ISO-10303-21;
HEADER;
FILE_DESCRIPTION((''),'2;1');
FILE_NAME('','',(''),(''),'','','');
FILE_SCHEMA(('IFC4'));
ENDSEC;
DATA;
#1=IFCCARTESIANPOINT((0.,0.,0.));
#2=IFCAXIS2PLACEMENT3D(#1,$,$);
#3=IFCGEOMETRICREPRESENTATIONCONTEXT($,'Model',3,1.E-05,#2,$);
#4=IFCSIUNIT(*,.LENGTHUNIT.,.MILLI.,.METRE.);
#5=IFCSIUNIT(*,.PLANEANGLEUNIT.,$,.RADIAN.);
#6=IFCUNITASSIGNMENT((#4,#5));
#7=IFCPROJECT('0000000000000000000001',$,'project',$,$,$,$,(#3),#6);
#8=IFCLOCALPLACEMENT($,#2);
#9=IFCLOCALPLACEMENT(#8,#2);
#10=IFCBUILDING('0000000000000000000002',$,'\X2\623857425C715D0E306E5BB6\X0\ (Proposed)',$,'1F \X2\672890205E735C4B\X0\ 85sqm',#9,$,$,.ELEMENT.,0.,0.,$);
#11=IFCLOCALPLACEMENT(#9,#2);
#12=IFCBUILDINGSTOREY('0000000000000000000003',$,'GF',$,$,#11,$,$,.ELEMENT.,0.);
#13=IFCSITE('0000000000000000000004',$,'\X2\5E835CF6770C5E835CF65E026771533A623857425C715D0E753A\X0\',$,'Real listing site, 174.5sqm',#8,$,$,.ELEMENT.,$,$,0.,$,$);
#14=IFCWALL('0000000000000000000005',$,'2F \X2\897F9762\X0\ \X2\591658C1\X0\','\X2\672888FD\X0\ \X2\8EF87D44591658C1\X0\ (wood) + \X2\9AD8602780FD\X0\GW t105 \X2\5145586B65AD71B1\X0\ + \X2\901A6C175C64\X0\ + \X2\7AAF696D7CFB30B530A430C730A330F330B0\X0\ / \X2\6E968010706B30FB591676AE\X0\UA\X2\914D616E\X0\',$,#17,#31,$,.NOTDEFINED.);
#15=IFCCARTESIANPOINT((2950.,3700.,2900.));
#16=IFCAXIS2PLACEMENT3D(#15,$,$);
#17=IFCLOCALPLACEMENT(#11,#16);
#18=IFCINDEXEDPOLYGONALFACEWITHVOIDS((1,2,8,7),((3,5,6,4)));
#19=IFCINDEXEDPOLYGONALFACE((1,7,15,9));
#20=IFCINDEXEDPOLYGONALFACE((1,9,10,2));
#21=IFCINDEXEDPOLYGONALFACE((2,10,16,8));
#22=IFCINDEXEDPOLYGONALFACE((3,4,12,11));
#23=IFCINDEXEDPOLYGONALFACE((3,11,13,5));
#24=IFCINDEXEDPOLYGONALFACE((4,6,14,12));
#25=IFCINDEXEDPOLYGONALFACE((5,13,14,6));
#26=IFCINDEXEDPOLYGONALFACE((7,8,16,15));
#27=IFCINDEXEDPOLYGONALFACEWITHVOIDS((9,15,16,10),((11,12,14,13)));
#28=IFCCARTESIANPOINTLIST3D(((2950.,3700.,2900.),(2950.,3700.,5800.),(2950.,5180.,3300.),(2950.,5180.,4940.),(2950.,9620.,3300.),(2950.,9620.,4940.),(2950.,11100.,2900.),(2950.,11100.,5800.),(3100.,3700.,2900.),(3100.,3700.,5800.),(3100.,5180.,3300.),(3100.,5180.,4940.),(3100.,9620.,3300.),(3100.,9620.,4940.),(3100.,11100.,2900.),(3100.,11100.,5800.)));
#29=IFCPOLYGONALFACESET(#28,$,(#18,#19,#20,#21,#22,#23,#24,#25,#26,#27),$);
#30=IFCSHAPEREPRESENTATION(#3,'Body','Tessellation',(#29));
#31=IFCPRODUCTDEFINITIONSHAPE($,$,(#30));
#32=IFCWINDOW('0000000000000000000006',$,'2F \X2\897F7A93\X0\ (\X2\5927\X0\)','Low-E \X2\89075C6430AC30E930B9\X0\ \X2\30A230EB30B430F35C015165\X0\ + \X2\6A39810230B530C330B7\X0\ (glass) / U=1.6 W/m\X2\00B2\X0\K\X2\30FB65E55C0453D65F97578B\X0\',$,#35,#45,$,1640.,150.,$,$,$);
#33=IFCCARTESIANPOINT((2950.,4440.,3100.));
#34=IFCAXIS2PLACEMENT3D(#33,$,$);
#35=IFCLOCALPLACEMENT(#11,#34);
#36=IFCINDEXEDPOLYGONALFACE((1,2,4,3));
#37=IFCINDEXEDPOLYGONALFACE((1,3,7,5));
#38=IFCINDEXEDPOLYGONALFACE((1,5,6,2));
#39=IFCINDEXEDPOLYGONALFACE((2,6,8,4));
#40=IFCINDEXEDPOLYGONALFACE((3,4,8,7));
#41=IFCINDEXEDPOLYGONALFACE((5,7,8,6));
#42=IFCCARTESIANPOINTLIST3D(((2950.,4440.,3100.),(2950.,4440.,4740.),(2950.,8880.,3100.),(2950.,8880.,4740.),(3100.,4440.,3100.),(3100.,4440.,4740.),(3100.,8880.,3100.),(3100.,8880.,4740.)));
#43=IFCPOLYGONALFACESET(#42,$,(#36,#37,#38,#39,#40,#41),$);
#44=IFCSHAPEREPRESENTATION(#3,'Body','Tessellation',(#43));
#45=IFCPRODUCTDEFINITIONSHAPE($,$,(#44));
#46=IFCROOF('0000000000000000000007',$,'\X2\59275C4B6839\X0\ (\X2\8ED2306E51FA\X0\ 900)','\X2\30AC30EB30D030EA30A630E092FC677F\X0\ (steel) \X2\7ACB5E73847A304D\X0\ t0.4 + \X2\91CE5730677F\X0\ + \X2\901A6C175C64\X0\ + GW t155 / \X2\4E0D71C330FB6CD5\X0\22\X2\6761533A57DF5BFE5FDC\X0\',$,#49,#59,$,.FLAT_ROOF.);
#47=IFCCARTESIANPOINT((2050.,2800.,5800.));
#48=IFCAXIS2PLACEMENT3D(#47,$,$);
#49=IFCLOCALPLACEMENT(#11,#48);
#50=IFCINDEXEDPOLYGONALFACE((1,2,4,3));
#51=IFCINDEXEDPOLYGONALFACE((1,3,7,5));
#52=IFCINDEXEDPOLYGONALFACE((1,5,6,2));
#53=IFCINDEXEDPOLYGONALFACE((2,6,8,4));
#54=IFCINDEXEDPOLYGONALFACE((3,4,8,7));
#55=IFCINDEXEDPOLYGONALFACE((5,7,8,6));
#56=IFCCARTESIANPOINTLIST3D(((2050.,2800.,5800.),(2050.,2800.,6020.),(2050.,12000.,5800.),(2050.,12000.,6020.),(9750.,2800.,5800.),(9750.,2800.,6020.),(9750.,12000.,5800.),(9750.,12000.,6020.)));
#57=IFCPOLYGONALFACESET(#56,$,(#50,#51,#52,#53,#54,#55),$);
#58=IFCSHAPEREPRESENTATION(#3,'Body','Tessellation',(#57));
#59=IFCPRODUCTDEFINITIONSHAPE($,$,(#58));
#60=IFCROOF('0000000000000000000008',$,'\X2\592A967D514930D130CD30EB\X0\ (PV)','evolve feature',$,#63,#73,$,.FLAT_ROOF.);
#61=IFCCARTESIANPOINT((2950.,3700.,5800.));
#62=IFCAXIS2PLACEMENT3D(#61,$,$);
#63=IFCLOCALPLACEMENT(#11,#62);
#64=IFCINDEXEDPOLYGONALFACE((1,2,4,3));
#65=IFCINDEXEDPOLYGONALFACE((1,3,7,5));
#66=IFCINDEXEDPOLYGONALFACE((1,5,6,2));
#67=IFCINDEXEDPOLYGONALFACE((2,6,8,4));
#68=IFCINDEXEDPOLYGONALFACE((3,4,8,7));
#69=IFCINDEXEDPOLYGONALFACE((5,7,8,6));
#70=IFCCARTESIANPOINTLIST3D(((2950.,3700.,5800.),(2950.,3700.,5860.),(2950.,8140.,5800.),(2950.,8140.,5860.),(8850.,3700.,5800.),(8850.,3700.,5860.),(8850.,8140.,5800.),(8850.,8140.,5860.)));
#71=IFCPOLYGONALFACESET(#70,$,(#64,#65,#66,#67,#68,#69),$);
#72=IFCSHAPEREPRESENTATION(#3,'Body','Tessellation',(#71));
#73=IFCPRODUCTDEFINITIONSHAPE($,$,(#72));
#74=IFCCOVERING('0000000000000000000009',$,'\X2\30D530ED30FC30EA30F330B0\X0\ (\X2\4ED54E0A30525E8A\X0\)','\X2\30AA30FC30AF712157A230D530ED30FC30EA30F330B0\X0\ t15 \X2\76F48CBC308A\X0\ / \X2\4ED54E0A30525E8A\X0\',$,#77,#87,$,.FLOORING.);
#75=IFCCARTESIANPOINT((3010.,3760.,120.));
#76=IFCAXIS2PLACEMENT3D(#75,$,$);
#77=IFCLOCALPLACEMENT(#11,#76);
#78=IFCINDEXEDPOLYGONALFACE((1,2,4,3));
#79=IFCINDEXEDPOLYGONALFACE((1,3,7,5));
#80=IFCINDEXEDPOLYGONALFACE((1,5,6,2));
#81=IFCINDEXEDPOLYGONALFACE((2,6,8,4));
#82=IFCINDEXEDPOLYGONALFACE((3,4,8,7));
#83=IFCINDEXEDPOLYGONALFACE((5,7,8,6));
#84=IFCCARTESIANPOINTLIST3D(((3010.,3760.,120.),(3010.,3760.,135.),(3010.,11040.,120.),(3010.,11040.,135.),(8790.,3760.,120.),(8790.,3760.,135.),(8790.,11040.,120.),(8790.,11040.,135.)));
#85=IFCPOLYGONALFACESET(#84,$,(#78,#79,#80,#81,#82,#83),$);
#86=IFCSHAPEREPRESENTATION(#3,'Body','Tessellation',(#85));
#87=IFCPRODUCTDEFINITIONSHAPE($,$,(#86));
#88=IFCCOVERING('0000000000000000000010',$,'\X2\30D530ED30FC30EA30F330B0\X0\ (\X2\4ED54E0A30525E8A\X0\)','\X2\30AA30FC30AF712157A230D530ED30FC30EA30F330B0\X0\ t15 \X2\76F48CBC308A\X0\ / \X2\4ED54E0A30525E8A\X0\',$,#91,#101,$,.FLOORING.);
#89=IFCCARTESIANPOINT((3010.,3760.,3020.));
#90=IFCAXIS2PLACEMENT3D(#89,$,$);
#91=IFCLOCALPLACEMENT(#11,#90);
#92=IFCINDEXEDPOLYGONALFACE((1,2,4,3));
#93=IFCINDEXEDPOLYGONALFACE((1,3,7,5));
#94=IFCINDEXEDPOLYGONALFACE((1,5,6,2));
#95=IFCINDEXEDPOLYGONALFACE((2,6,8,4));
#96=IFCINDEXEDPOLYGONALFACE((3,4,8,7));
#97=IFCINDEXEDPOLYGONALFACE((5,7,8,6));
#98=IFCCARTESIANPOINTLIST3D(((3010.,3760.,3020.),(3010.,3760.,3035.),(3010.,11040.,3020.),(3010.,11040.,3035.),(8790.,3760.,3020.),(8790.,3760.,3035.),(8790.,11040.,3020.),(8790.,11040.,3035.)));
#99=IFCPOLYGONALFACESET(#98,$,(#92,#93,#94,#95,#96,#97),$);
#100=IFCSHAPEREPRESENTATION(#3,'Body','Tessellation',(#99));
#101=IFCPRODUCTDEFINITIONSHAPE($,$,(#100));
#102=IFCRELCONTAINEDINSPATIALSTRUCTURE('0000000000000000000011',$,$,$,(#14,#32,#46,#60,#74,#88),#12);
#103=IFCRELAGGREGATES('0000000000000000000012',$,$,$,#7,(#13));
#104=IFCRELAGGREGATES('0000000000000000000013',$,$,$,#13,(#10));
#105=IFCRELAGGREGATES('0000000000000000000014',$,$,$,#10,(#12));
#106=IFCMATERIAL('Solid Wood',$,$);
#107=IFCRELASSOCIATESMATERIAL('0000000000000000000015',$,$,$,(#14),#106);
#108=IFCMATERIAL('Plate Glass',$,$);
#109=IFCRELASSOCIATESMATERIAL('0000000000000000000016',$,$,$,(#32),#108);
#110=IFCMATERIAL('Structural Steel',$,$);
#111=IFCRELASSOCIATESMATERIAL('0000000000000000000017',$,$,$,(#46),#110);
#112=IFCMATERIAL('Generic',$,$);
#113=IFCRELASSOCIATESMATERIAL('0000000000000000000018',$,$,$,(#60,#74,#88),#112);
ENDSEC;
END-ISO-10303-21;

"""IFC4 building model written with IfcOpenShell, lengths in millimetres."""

from ifc_helpers import new_model, si_unit, frame, frame_2d, origin, place, context, project, spatial, rectangle, extrude, material, element, fill, save


model = new_model("IFC4")

# Units and contexts
model_context = context("Model", 3, precision=1e-05, world=origin())
ifc_project = project(units=[si_unit("LENGTHUNIT", "METRE", prefix="MILLI"), si_unit("PLANEANGLEUNIT", "RADIAN")], contexts=[model_context])

# Site, building, storey
site_placement = place(None, origin())
site = spatial("IfcSite", under=ifc_project, at=site_placement, Name="広島県広島市東区戸坂山崎町", ObjectType="Real listing site, 174.5sqm", CompositionType="ELEMENT", RefElevation=0.0)
building_placement = place(site_placement, origin())
building = spatial("IfcBuilding", under=site, at=building_placement, Name="戸坂山崎の家 (Proposed)", ObjectType="1F 木造平屋 85sqm", CompositionType="ELEMENT", ElevationOfRefHeight=0.0, ElevationOfTerrain=0.0)
storey_placement = place(building_placement, origin())
storey = spatial("IfcBuildingStorey", under=building, at=storey_placement, Name="GF", CompositionType="ELEMENT", Elevation=0.0)

# Shared definitions
ifc_material_1 = material(Name="Solid Wood")
ifc_material_2 = material(Name="Generic")

# Shared definitions
ifc_material_3 = material(Name="Plate Glass")

# Wall, opening, window
wall_1_placement = place(storey_placement, frame((2950.0, 3700.0, 2900.0)))
wall_1 = element("IfcWall", 1, at=wall_1_placement, inside=storey, material=ifc_material_1, Name="2F 西面 外壁", Description="木製 軸組外壁 (wood) + 高性能GW t105 充填断熱 + 通気層 + 窯業系サイディング / 準耐火・外皮UA配慮", PredefinedType="NOTDEFINED", context=model_context, shape_type="SweptSolid", body=[
    extrude(rectangle(XDim=150.0, YDim=7400.0, at=frame_2d((75.0, 3700.0))), frame((2950.0, 3700.0, 2900.0)), (0.0, 0.0, 1.0), 2900.0),
])
opening_1_placement = place(storey_placement, frame((2950.0, 4440.0, 3100.0)))
opening_1 = element("IfcOpeningElement", 2, at=opening_1_placement, cuts=wall_1, PredefinedType="NOTDEFINED", context=model_context, shape_type="SweptSolid", body=[
    extrude(rectangle(XDim=150.0, YDim=4440.0, at=frame_2d((75.0, 2220.0))), frame((2950.0, 4440.0, 3100.0)), (0.0, 0.0, 1.0), 1640.0),
])
window_1_placement = place(storey_placement, frame((2950.0, 4440.0, 3100.0)))
window_1 = element("IfcWindow", 3, at=window_1_placement, inside=storey, material=ifc_material_3, Name="2F 西窓 (大)", Description="Low-E 複層ガラス アルゴン封入 + 樹脂サッシ (glass) / U=1.6 W/m²K・日射取得型", OverallHeight=1640.0, OverallWidth=150.0, context=model_context, shape_type="SweptSolid", body=[
    extrude(rectangle(XDim=150.0, YDim=4440.0, at=frame_2d((75.0, 2220.0))), frame((2950.0, 4440.0, 3100.0)), (0.0, 0.0, 1.0), 1640.0),
])
fill(opening_1, window_1)

# Roofs
ifc_material_4 = material(Name="Structural Steel")
roof_1_placement = place(storey_placement, frame((2050.0, 2800.0, 5800.0)))
element("IfcRoof", 4, at=roof_1_placement, inside=storey, material=ifc_material_4, Name="大屋根 (軒の出 900)", Description="ガルバリウム鋼板 (steel) 立平葺き t0.4 + 野地板 + 通気層 + GW t155 / 不燃・法22条区域対応", PredefinedType="FLAT_ROOF", context=model_context, shape_type="SweptSolid", body=[
    extrude(rectangle(XDim=7700.0, YDim=9200.0, at=frame_2d((3850.0, 4600.0))), frame((2050.0, 2800.0, 5800.0)), (0.0, 0.0, 1.0), 220.0),
])
roof_2_placement = place(storey_placement, frame((2950.0, 3700.0, 5800.0)))
element("IfcRoof", 5, at=roof_2_placement, inside=storey, material=ifc_material_2, Name="太陽光パネル (PV)", Description="evolve feature", PredefinedType="FLAT_ROOF", context=model_context, shape_type="SweptSolid", body=[
    extrude(rectangle(XDim=5900.0, YDim=4440.0, at=frame_2d((2950.0, 2220.0))), frame((2950.0, 3700.0, 5800.0)), (0.0, 0.0, 1.0), 60.0),
])

# Coverings
covering_1_placement = place(storey_placement, frame((3010.0, 3760.0, 120.0)))
element("IfcCovering", 6, at=covering_1_placement, inside=storey, material=ifc_material_2, Name="フローリング (仕上げ床)", Description="オーク無垢フローリング t15 直貼り / 仕上げ床", PredefinedType="FLOORING", context=model_context, shape_type="SweptSolid", body=[
    extrude(rectangle(XDim=5780.0, YDim=7280.0, at=frame_2d((2890.0, 3640.0))), frame((3010.0, 3760.0, 120.0)), (0.0, 0.0, 1.0), 15.0),
])
covering_2_placement = place(storey_placement, frame((3010.0, 3760.0, 3020.0)))
element("IfcCovering", 7, at=covering_2_placement, inside=storey, material=ifc_material_2, Name="フローリング (仕上げ床)", Description="オーク無垢フローリング t15 直貼り / 仕上げ床", PredefinedType="FLOORING", context=model_context, shape_type="SweptSolid", body=[
    extrude(rectangle(XDim=5780.0, YDim=7280.0, at=frame_2d((2890.0, 3640.0))), frame((3010.0, 3760.0, 3020.0)), (0.0, 0.0, 1.0), 15.0),
])

save(model, "model.ifc")
